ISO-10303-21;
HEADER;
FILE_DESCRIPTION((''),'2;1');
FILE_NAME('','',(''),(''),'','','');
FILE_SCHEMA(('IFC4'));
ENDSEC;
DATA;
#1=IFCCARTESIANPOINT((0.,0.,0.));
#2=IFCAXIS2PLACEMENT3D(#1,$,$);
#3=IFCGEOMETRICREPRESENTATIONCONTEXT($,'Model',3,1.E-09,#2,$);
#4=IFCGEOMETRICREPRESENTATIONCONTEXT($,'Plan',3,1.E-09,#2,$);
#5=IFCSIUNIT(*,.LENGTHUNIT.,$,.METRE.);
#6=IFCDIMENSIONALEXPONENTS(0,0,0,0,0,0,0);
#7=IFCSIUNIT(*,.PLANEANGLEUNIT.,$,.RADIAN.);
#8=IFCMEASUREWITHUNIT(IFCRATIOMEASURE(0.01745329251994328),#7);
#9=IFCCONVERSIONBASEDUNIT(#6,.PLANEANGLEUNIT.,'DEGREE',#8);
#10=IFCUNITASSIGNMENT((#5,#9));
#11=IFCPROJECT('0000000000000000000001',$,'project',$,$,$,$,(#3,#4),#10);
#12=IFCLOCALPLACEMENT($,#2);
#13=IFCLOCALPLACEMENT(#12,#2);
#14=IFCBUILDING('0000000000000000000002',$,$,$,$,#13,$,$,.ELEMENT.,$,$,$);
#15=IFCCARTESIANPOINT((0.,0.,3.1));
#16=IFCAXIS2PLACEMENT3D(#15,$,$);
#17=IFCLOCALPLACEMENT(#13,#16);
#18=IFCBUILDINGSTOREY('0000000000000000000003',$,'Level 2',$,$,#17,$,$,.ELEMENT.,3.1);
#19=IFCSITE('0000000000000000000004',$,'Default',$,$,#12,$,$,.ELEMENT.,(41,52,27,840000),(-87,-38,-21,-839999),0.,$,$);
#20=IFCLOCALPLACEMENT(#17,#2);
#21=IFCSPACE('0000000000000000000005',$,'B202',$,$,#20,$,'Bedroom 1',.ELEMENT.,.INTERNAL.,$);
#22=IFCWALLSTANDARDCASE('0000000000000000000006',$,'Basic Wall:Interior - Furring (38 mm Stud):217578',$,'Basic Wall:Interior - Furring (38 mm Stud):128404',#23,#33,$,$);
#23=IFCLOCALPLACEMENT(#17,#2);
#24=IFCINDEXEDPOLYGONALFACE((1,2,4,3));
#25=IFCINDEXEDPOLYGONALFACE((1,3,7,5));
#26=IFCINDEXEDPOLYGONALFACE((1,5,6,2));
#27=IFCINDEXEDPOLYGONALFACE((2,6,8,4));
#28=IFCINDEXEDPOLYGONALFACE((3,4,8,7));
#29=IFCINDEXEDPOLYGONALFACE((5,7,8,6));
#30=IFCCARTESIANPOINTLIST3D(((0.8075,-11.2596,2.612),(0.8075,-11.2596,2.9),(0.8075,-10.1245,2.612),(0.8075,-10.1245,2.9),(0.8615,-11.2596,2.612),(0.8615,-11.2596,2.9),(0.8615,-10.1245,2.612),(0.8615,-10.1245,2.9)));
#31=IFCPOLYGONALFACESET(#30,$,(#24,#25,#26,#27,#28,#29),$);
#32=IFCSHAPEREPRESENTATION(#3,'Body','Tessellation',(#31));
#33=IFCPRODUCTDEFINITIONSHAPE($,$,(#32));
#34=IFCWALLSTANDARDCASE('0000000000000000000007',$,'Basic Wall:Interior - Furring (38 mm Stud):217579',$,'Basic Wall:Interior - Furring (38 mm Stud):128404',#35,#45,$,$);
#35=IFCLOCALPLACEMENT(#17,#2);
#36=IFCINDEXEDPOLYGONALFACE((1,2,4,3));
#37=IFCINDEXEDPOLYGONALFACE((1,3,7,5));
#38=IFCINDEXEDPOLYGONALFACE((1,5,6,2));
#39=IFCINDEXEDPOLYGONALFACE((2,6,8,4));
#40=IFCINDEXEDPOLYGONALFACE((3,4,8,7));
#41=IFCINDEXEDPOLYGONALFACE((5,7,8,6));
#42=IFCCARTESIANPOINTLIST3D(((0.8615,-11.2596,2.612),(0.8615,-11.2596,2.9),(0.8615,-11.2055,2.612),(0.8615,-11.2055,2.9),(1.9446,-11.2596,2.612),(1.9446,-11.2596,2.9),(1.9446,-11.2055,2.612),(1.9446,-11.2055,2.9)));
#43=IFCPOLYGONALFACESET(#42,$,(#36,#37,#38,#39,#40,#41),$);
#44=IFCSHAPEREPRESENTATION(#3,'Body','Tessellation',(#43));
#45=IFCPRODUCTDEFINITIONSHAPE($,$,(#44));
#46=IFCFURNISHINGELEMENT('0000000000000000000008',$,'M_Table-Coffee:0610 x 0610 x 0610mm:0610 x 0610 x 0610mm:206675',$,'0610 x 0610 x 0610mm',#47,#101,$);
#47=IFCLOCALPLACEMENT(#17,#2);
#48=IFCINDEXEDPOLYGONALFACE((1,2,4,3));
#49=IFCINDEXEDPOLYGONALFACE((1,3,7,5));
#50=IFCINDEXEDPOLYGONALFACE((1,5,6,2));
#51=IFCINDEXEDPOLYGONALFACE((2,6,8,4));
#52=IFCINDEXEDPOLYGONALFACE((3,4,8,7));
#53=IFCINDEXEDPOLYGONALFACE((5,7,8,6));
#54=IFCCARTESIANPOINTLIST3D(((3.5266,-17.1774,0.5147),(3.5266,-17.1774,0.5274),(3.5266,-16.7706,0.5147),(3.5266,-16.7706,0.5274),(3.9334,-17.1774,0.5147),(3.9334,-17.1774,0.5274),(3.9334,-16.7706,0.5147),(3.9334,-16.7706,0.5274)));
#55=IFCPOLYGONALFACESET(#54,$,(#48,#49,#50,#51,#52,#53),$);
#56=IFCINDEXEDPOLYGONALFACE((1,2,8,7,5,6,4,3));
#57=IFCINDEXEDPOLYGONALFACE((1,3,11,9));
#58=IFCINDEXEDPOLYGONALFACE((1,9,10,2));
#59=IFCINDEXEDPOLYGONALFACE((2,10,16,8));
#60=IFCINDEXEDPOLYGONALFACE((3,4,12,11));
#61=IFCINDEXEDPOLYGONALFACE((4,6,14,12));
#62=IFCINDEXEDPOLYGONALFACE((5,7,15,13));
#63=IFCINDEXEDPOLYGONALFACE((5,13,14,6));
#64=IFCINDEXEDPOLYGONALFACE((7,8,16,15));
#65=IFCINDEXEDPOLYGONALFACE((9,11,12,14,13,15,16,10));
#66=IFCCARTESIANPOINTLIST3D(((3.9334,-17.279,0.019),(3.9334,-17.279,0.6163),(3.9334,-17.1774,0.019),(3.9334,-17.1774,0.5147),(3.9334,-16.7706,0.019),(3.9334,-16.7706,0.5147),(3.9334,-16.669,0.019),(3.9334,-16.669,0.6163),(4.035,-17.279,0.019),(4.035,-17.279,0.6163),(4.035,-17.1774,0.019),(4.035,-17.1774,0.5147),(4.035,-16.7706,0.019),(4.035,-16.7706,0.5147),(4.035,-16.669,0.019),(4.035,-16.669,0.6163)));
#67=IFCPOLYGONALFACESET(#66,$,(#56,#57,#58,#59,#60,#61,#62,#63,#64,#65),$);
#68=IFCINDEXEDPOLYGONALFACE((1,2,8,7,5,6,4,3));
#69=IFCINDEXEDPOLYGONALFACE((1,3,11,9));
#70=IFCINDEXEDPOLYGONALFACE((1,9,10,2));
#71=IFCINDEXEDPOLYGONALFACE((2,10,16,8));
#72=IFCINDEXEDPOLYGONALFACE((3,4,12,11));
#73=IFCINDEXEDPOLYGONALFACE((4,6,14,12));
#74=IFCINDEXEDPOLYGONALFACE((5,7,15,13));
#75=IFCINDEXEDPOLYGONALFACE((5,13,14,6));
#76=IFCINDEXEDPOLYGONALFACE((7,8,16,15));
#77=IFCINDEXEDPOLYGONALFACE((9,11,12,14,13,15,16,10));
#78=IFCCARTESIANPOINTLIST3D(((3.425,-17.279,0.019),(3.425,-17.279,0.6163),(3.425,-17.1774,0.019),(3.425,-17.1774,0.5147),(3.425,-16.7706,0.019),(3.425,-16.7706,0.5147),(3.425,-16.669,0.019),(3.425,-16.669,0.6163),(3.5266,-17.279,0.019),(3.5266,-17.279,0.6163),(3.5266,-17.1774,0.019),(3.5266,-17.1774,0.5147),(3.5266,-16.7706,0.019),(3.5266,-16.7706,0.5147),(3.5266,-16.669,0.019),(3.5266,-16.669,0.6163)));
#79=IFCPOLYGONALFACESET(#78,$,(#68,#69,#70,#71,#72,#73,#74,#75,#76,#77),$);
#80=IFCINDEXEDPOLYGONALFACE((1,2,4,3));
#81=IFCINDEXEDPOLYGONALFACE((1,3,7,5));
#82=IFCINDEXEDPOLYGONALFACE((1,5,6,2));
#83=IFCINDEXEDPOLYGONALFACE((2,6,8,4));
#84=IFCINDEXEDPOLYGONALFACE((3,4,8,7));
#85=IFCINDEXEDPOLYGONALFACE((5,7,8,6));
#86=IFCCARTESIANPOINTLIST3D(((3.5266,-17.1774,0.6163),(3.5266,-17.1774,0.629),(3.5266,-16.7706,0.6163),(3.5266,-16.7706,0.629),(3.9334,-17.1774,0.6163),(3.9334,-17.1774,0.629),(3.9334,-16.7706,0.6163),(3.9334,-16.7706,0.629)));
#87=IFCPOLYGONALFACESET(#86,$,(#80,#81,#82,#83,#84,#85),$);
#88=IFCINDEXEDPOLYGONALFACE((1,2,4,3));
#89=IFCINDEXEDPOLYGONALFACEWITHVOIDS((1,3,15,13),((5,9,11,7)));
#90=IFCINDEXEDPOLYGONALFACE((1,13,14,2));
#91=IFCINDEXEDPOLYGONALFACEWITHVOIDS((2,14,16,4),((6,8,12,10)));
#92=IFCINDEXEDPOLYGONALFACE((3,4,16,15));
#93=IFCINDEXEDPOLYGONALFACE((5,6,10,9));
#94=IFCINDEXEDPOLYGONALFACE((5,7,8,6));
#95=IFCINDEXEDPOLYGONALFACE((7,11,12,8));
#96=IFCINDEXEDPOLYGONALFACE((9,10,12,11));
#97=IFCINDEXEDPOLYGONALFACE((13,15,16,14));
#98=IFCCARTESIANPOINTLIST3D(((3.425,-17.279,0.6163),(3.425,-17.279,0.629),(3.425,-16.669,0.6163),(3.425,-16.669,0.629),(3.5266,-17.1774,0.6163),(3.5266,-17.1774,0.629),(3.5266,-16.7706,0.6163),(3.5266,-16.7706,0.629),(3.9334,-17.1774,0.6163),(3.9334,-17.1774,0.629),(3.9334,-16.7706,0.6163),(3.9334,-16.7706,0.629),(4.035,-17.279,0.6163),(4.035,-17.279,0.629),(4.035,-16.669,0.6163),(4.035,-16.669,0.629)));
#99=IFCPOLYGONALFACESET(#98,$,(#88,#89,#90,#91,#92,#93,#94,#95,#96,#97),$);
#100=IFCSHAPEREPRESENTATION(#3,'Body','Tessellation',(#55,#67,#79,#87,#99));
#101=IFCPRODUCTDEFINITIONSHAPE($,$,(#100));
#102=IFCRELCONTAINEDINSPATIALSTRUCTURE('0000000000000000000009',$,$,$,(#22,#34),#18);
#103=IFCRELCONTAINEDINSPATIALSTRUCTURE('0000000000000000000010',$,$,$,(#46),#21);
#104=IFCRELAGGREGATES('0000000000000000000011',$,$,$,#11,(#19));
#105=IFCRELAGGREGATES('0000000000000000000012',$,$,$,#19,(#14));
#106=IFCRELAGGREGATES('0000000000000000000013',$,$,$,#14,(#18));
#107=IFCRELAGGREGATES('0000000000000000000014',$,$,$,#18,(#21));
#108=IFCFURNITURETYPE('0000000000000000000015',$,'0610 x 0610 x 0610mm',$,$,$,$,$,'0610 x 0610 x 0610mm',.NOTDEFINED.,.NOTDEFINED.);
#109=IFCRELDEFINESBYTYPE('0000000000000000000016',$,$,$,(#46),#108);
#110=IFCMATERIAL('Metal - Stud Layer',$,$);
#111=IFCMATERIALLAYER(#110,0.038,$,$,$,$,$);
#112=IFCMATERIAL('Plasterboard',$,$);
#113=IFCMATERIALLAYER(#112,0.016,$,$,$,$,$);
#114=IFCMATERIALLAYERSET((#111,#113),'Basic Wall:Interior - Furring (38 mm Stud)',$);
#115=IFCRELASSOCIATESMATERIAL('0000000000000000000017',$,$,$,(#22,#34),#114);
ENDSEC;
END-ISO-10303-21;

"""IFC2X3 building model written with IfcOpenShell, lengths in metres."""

from ifc_helpers import new_model, entity, si_unit, converted_unit, frame, frame_2d, origin, origin_2d_with_axis, place, context, project, spatial, polyline, rectangle, outline, extrude, source, transform, mapped, material, layer, layer_set, layer_usage, type_object, type_shapes, element, save


model = new_model("IFC2X3")

# Units and contexts
model_context = context("Model", 3, precision=1e-09, world=origin())
plan_context = context("Plan", 3, precision=1e-09, world=origin())
ifc_project = project(units=[si_unit("LENGTHUNIT", "METRE"), converted_unit("PLANEANGLEUNIT", "DEGREE", entity("IfcRatioMeasure", 0.01745329251994328), si_unit("PLANEANGLEUNIT", "RADIAN"), dimensions=[0, 0, 0, 0, 0, 0, 0])], contexts=[model_context, plan_context])

# Site, building, storey
site_placement = place(None, origin())
site = spatial("IfcSite", under=ifc_project, at=site_placement, Name="Default", CompositionType="ELEMENT", RefLatitude=(41, 52, 27, 840000), RefLongitude=(-87, -38, -21, -839999), RefElevation=0.0)
building_placement = place(site_placement, origin())
building = spatial("IfcBuilding", under=site, at=building_placement, CompositionType="ELEMENT")
storey_placement = place(building_placement, frame((0.0, 0.0, 3.1)))
storey = spatial("IfcBuildingStorey", under=building, at=storey_placement, Name="Level 2", CompositionType="ELEMENT", Elevation=3.1)

# Shared definitions
ifc_material_1 = material(Name="Metal - Stud Layer")
ifc_material_2 = material(Name="Plasterboard")

# Walls
ifc_layer_1 = layer(ifc_material_1, 0.038)
ifc_layer_2 = layer(ifc_material_2, 0.016)
ifc_layer_set_1 = layer_set([ifc_layer_1, ifc_layer_2], Name="Basic Wall:Interior - Furring (38 mm Stud)")
ifc_layer_usage_1 = layer_usage(ifc_layer_set_1, "AXIS2", "NEGATIVE", 0.027)
wall_1_placement = place(storey_placement, frame((0.8345, -11.2596, 2.612), z_axis=(0.0, 0.0, 1.0), x_axis=(0.0, 1.0, 0.0)))
element("IfcWallStandardCase", 1, at=wall_1_placement, inside=storey, material=ifc_layer_usage_1, Name="Basic Wall:Interior - Furring (38 mm Stud):217578", ObjectType="Basic Wall:Interior - Furring (38 mm Stud):128404", context=model_context, shape_type="SweptSolid", body=[
    extrude(rectangle(XDim=1.1351, YDim=0.054, at=frame_2d((0.5675, 0.0), x_axis=(-1.0, 0.0))), origin(), (0.0, 0.0, 1.0), 0.288),
])
ifc_layer_usage_2 = layer_usage(ifc_layer_set_1, "AXIS2", "NEGATIVE", 0.027)
wall_2_placement = place(storey_placement, frame((1.9446, -11.2325, 2.612), z_axis=(0.0, 0.0, 1.0), x_axis=(-1.0, 0.0, 0.0)))
element("IfcWallStandardCase", 2, at=wall_2_placement, inside=storey, material=ifc_layer_usage_2, Name="Basic Wall:Interior - Furring (38 mm Stud):217579", ObjectType="Basic Wall:Interior - Furring (38 mm Stud):128404", context=model_context, shape_type="SweptSolid", body=[
    extrude(rectangle(XDim=1.0831, YDim=0.054, at=frame_2d((0.5415, 0.0), x_axis=(-1.0, 0.0))), origin(), (0.0, 0.0, 1.0), 0.288),
])

# Shared definitions
space_placement = place(storey_placement, origin())
space = spatial("IfcSpace", under=storey, at=space_placement, Name="B202", LongName="Bedroom 1", CompositionType="ELEMENT", InteriorOrExteriorSpace="INTERNAL")

# Furnishing element
furniture_type = type_object("IfcFurnitureType", Name="0610 x 0610 x 0610mm", ElementType="0610 x 0610 x 0610mm", AssemblyPlace="NOTDEFINED")
shared_shape_1 = source(origin(), model_context, "Body", "SweptSolid", [
    extrude(rectangle(XDim=0.4068, YDim=0.4068, at=origin_2d_with_axis()), frame((0.0183, 0.0952, 0.4957), z_axis=(0.0, 0.0, 1.0), x_axis=(-1.0, 0.0, 0.0)), (0.0, 0.0, 1.0), 0.0127),
    extrude(outline(polyline([(-0.2732, -0.305), (0.324, -0.305), (0.324, 0.305), (-0.2732, 0.305), (-0.2732, 0.2034), (0.2225, 0.2034), (0.2225, -0.2034), (-0.2732, -0.2034), (-0.2732, -0.305)])), frame((0.2217, 0.0952, 0.2732), z_axis=(1.0, 0.0, 0.0), x_axis=(0.0, 0.0, 1.0)), (0.0, 0.0, 1.0), 0.1016),
    extrude(outline(polyline([(-0.305, -0.3241), (0.305, -0.3241), (0.305, 0.2733), (0.2034, 0.2733), (0.2034, -0.2224), (-0.2034, -0.2224), (-0.2034, 0.2733), (-0.305, 0.2733), (-0.305, -0.3241)])), frame((-0.2867, 0.0952, 0.2733), z_axis=(1.0, 0.0, 0.0), x_axis=(0.0, -1.0, 0.0)), (0.0, 0.0, 1.0), 0.1016),
    extrude(rectangle(XDim=0.4068, YDim=0.4068, at=origin_2d_with_axis()), frame((0.0183, 0.0952, 0.5973), z_axis=(0.0, 0.0, 1.0), x_axis=(-1.0, 0.0, 0.0)), (0.0, 0.0, 1.0), 0.0127),
    extrude(outline(polyline([(-0.305, -0.305), (0.305, -0.305), (0.305, 0.305), (-0.305, 0.305), (-0.305, -0.305)]), holes=[polyline([(-0.2034, -0.2034), (-0.2034, 0.2034), (0.2034, 0.2034), (0.2034, -0.2034), (-0.2034, -0.2034)])]), frame((0.0183, 0.0952, 0.5973), z_axis=(0.0, 0.0, 1.0), x_axis=(-1.0, 0.0, 0.0)), (0.0, 0.0, 1.0), 0.0127),
])
type_shapes(furniture_type, [shared_shape_1])
furnishing_placement = place(space_placement, frame((3.7117, -17.0692, 0.019)))
element("IfcFurnishingElement", 3, at=furnishing_placement, inside=space, type_object=furniture_type, Name="M_Table-Coffee:0610 x 0610 x 0610mm:0610 x 0610 x 0610mm:206675", ObjectType="0610 x 0610 x 0610mm", context=model_context, shape_type="MappedRepresentation", body=[
    mapped(shared_shape_1, transform((0.0, 0.0, 0.0), scale=1.0)),
])

save(model, "model.ifc")
